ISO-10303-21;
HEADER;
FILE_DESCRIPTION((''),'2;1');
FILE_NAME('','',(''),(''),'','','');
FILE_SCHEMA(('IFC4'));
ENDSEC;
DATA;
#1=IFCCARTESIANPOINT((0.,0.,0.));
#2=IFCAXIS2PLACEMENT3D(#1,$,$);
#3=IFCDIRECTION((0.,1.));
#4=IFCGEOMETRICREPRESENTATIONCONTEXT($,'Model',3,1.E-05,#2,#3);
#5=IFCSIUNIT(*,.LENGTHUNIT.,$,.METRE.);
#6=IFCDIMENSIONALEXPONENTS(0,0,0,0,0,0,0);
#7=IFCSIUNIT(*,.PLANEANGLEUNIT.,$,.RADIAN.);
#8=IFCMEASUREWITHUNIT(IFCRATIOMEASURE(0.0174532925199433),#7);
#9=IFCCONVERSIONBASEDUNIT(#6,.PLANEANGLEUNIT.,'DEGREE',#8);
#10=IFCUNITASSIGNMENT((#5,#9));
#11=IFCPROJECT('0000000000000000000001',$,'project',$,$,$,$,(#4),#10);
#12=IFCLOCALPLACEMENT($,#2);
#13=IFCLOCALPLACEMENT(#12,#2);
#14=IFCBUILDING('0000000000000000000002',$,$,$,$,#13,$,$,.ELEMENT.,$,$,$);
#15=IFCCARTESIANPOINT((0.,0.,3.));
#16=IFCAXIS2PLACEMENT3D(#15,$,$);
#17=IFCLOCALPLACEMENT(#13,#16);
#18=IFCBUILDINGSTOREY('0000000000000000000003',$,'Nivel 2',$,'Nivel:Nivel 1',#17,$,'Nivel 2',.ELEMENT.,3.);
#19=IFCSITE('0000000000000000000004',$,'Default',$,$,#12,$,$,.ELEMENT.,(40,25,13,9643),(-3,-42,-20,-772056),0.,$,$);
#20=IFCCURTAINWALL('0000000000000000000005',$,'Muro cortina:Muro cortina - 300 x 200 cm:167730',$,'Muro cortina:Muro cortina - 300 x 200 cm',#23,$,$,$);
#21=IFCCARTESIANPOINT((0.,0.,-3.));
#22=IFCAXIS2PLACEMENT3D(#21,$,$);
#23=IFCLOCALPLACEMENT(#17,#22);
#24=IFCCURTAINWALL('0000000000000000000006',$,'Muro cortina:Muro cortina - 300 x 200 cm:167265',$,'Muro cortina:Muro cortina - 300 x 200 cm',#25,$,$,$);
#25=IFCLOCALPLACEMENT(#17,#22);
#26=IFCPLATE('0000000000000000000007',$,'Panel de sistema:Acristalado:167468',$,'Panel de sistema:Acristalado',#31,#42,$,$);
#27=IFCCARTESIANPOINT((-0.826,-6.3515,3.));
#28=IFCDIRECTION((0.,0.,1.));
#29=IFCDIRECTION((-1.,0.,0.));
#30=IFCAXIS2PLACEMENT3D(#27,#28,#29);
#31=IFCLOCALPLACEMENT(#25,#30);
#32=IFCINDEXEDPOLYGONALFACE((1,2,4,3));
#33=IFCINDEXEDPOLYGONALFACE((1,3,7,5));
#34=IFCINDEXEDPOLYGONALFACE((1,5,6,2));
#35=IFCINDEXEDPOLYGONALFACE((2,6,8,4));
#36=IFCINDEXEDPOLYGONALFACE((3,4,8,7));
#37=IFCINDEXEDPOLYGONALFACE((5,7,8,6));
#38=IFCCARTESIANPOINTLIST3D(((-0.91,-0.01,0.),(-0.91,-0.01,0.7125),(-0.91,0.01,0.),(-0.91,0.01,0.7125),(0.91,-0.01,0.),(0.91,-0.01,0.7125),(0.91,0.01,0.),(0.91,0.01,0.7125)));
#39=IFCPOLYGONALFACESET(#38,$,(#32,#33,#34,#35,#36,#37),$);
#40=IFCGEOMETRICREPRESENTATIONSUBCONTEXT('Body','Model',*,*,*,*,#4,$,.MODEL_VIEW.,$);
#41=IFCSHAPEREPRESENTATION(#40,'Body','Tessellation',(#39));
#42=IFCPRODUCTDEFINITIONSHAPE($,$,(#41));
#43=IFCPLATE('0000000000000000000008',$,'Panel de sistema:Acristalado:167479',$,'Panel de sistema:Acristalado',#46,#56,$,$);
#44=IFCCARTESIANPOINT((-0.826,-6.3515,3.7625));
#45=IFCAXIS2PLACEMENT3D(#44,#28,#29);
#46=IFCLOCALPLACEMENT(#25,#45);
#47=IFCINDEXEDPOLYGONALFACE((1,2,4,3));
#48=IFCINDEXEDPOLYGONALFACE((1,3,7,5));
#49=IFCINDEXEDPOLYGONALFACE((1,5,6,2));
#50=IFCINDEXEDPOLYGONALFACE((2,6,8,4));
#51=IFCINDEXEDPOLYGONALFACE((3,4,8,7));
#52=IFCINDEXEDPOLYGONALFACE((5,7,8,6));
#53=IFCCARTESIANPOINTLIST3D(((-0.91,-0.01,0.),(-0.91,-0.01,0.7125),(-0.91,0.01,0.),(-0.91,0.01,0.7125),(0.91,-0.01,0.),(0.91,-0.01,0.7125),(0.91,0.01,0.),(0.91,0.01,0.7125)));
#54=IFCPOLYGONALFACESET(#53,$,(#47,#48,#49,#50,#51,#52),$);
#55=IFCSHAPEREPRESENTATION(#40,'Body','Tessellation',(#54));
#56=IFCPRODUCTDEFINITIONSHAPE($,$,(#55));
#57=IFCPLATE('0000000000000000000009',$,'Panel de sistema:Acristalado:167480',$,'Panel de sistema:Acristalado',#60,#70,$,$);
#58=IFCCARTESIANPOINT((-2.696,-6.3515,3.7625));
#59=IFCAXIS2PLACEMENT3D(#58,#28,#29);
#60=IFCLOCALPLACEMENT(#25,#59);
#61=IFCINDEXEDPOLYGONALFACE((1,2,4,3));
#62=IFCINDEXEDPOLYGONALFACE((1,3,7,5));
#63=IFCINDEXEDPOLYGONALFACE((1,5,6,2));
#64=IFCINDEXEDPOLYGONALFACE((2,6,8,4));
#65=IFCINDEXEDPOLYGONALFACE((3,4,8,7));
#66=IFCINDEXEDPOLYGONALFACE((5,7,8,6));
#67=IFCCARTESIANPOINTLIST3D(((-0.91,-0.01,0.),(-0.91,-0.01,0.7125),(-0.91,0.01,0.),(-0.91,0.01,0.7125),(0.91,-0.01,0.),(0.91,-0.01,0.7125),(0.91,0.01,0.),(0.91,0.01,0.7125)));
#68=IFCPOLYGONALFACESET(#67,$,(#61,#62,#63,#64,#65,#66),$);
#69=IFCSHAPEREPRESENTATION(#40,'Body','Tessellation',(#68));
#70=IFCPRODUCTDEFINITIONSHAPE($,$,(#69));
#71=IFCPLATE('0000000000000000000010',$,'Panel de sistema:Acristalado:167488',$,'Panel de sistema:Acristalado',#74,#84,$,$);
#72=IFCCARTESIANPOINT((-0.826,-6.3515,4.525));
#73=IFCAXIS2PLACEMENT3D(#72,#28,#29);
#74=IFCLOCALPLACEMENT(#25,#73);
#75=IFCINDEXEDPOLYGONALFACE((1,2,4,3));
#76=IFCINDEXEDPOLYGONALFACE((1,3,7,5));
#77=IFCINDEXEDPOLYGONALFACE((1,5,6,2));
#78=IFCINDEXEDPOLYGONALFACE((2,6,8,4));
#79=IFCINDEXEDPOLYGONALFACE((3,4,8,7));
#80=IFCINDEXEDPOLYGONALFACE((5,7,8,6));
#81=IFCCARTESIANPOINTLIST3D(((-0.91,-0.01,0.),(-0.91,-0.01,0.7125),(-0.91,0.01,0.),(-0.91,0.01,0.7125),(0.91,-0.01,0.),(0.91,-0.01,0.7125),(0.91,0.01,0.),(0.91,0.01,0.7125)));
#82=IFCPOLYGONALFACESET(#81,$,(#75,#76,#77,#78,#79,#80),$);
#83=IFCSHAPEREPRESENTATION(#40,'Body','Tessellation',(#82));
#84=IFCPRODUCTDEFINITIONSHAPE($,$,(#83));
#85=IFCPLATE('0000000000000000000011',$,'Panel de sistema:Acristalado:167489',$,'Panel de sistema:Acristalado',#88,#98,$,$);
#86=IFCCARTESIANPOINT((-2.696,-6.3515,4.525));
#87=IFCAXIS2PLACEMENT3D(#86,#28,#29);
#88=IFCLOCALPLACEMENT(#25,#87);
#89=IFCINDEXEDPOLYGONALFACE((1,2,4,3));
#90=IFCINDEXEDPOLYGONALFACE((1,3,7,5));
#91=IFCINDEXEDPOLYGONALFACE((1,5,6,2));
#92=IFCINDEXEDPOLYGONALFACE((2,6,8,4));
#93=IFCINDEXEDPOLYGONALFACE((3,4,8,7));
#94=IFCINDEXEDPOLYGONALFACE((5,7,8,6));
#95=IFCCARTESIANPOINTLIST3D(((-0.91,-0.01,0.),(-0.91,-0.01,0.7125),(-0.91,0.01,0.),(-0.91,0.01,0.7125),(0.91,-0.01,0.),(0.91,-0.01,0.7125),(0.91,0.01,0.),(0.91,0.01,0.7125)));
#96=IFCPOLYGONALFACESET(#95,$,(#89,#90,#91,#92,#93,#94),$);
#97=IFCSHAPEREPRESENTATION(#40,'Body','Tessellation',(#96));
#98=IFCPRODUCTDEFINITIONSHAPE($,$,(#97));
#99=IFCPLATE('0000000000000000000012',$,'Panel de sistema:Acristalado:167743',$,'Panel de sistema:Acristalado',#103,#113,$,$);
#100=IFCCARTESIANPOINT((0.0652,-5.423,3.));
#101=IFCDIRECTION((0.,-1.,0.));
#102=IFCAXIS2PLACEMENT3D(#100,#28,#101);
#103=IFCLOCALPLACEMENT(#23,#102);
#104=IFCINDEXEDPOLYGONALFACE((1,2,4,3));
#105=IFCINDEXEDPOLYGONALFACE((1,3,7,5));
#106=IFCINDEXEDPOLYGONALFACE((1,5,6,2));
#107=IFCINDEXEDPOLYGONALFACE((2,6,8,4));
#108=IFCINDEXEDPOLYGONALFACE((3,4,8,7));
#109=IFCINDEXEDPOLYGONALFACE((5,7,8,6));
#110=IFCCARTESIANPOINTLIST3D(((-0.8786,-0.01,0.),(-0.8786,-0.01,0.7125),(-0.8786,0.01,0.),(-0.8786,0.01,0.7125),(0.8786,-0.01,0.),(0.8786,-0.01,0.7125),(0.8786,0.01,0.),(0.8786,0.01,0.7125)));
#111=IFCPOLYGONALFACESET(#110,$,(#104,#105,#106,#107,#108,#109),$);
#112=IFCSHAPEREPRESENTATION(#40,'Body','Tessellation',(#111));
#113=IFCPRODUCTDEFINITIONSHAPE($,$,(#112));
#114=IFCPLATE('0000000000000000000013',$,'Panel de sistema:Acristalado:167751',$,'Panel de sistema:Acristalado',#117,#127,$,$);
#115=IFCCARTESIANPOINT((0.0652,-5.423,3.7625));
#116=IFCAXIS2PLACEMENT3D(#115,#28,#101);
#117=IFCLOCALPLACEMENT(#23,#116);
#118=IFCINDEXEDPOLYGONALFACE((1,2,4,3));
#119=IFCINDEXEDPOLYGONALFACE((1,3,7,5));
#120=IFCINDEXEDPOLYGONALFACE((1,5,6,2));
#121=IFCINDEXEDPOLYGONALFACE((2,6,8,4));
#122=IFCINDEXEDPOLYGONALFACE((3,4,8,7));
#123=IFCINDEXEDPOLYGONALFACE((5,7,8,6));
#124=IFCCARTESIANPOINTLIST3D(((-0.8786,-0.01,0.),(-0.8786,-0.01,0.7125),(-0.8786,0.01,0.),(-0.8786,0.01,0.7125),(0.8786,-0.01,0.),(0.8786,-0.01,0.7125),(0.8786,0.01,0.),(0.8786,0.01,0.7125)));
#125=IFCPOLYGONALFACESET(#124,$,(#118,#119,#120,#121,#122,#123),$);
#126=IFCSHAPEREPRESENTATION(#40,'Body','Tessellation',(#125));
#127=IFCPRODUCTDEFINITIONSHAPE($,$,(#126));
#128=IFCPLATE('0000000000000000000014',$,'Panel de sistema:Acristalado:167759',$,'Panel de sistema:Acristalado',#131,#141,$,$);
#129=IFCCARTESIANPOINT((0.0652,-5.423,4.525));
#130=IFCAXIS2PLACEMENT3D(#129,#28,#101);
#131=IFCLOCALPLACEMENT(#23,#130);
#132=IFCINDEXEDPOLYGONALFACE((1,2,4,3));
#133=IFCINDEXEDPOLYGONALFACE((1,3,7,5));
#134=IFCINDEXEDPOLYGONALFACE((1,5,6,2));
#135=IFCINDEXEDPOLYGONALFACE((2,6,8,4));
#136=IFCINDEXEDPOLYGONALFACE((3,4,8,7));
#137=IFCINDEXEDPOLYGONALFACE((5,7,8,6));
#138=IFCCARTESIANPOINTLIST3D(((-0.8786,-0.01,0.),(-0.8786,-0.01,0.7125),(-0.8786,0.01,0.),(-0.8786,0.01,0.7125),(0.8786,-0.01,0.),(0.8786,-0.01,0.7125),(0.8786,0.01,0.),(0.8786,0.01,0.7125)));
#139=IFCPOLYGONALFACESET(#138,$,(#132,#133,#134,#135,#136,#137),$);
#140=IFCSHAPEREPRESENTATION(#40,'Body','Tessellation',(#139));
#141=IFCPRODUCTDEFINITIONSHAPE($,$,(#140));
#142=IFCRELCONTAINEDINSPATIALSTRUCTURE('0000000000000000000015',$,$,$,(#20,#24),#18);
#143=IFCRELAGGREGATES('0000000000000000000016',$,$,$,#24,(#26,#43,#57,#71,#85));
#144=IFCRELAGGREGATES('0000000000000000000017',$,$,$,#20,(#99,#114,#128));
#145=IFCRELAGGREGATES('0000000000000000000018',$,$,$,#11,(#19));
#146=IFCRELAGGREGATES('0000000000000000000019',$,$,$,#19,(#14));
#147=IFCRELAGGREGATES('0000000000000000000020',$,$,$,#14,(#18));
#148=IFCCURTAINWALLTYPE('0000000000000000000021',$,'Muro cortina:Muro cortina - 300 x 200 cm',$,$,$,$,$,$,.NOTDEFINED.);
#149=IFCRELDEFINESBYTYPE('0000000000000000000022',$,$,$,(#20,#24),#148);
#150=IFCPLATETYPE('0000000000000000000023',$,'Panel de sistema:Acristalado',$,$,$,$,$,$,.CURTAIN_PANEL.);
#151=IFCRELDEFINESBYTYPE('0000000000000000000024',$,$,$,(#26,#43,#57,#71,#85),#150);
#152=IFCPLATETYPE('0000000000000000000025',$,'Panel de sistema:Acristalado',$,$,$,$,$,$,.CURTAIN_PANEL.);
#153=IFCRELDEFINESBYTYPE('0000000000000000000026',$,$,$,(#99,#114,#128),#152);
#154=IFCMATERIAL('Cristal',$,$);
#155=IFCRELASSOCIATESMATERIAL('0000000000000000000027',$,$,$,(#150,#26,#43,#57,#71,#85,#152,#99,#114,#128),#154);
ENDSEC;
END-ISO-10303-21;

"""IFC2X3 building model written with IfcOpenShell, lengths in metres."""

from ifc_helpers import new_model, entity, si_unit, converted_unit, direction, frame, origin, origin_2d_with_axis, place, context, subcontext, project, spatial, rectangle, extrude, source, transform, mapped, material, type_object, type_shapes, element, aggregate, save


model = new_model("IFC2X3")

# Units and contexts
model_context = context("Model", 3, precision=1e-05, world=origin(), true_north=direction((0.0, 1.0)))
body_context = subcontext(model_context, "Body", "Model", "MODEL_VIEW")
ifc_project = project(units=[si_unit("LENGTHUNIT", "METRE"), converted_unit("PLANEANGLEUNIT", "DEGREE", entity("IfcRatioMeasure", 0.0174532925199433), si_unit("PLANEANGLEUNIT", "RADIAN"), dimensions=[0, 0, 0, 0, 0, 0, 0])], contexts=[model_context])

# Site, building, storey
site_placement = place(None, origin())
site = spatial("IfcSite", under=ifc_project, at=site_placement, Name="Default", CompositionType="ELEMENT", RefLatitude=(40, 25, 13, 9643), RefLongitude=(-3, -42, -20, -772056), RefElevation=0.0)
building_placement = place(site_placement, origin())
building = spatial("IfcBuilding", under=site, at=building_placement, CompositionType="ELEMENT")
storey_placement = place(building_placement, frame((0.0, 0.0, 3.0)))
storey = spatial("IfcBuildingStorey", under=building, at=storey_placement, Name="Nivel 2", ObjectType="Nivel:Nivel 1", LongName="Nivel 2", CompositionType="ELEMENT", Elevation=3.0)

# Curtain walls
curtain_wall_type = type_object("IfcCurtainWallType", Name="Muro cortina:Muro cortina - 300 x 200 cm", PredefinedType="NOTDEFINED")
curtain_wall_1_placement = place(storey_placement, frame((0.0, 0.0, -3.0)))
curtain_wall_1 = element("IfcCurtainWall", 1, at=curtain_wall_1_placement, inside=storey, type_object=curtain_wall_type, Name="Muro cortina:Muro cortina - 300 x 200 cm:167730", ObjectType="Muro cortina:Muro cortina - 300 x 200 cm")
curtain_wall_2_placement = place(storey_placement, frame((0.0, 0.0, -3.0)))
curtain_wall_2 = element("IfcCurtainWall", 2, at=curtain_wall_2_placement, inside=storey, type_object=curtain_wall_type, Name="Muro cortina:Muro cortina - 300 x 200 cm:167265", ObjectType="Muro cortina:Muro cortina - 300 x 200 cm")

# Plates
ifc_material_1 = material(Name="Cristal")
plate_type_1 = type_object("IfcPlateType", Name="Panel de sistema:Acristalado", PredefinedType="CURTAIN_PANEL", material=ifc_material_1)
shared_shape_1 = source(origin(), body_context, "Body", "SweptSolid", [
    extrude(rectangle(XDim=0.02, YDim=1.82, at=origin_2d_with_axis()), frame((0.0, 0.0, 0.0), z_axis=(0.0, 0.0, 1.0), x_axis=(0.0, 1.0, 0.0)), (0.0, 0.0, 1.0), 0.7125),
])
type_shapes(plate_type_1, [shared_shape_1])
plate_1_placement = place(curtain_wall_2_placement, frame((-0.826, -6.3515, 3.0), z_axis=(0.0, 0.0, 1.0), x_axis=(-1.0, 0.0, 0.0)))
plate_1 = element("IfcPlate", 3, at=plate_1_placement, type_object=plate_type_1, material=ifc_material_1, Name="Panel de sistema:Acristalado:167468", ObjectType="Panel de sistema:Acristalado", context=body_context, shape_type="MappedRepresentation", body=[
    mapped(shared_shape_1, transform((0.0, 0.0, 0.0), scale=1.0)),
])
plate_2_placement = place(curtain_wall_2_placement, frame((-0.826, -6.3515, 3.7625), z_axis=(0.0, 0.0, 1.0), x_axis=(-1.0, 0.0, 0.0)))
plate_2 = element("IfcPlate", 4, at=plate_2_placement, type_object=plate_type_1, material=ifc_material_1, Name="Panel de sistema:Acristalado:167479", ObjectType="Panel de sistema:Acristalado", context=body_context, shape_type="MappedRepresentation", body=[
    mapped(shared_shape_1, transform((0.0, 0.0, 0.0), scale=1.0)),
])
plate_3_placement = place(curtain_wall_2_placement, frame((-2.696, -6.3515, 3.7625), z_axis=(0.0, 0.0, 1.0), x_axis=(-1.0, 0.0, 0.0)))
plate_3 = element("IfcPlate", 5, at=plate_3_placement, type_object=plate_type_1, material=ifc_material_1, Name="Panel de sistema:Acristalado:167480", ObjectType="Panel de sistema:Acristalado", context=body_context, shape_type="MappedRepresentation", body=[
    mapped(shared_shape_1, transform((0.0, 0.0, 0.0), scale=1.0)),
])
plate_4_placement = place(curtain_wall_2_placement, frame((-0.826, -6.3515, 4.525), z_axis=(0.0, 0.0, 1.0), x_axis=(-1.0, 0.0, 0.0)))
plate_4 = element("IfcPlate", 6, at=plate_4_placement, type_object=plate_type_1, material=ifc_material_1, Name="Panel de sistema:Acristalado:167488", ObjectType="Panel de sistema:Acristalado", context=body_context, shape_type="MappedRepresentation", body=[
    mapped(shared_shape_1, transform((0.0, 0.0, 0.0), scale=1.0)),
])
plate_5_placement = place(curtain_wall_2_placement, frame((-2.696, -6.3515, 4.525), z_axis=(0.0, 0.0, 1.0), x_axis=(-1.0, 0.0, 0.0)))
plate_5 = element("IfcPlate", 7, at=plate_5_placement, type_object=plate_type_1, material=ifc_material_1, Name="Panel de sistema:Acristalado:167489", ObjectType="Panel de sistema:Acristalado", context=body_context, shape_type="MappedRepresentation", body=[
    mapped(shared_shape_1, transform((0.0, 0.0, 0.0), scale=1.0)),
])
aggregate(curtain_wall_2, [plate_1, plate_2, plate_3, plate_4, plate_5])
plate_type_2 = type_object("IfcPlateType", Name="Panel de sistema:Acristalado", PredefinedType="CURTAIN_PANEL", material=ifc_material_1)
shared_shape_2 = source(origin(), body_context, "Body", "SweptSolid", [
    extrude(rectangle(XDim=0.02, YDim=1.7571, at=origin_2d_with_axis()), frame((0.0, 0.0, 0.0), z_axis=(0.0, 0.0, 1.0), x_axis=(0.0, 1.0, 0.0)), (0.0, 0.0, 1.0), 0.7125),
])
type_shapes(plate_type_2, [shared_shape_2])
plate_6_placement = place(curtain_wall_1_placement, frame((0.0652, -5.423, 3.0), z_axis=(0.0, 0.0, 1.0), x_axis=(0.0, -1.0, 0.0)))
plate_6 = element("IfcPlate", 8, at=plate_6_placement, type_object=plate_type_2, material=ifc_material_1, Name="Panel de sistema:Acristalado:167743", ObjectType="Panel de sistema:Acristalado", context=body_context, shape_type="MappedRepresentation", body=[
    mapped(shared_shape_2, transform((0.0, 0.0, 0.0), scale=1.0)),
])
plate_7_placement = place(curtain_wall_1_placement, frame((0.0652, -5.423, 3.7625), z_axis=(0.0, 0.0, 1.0), x_axis=(0.0, -1.0, 0.0)))
plate_7 = element("IfcPlate", 9, at=plate_7_placement, type_object=plate_type_2, material=ifc_material_1, Name="Panel de sistema:Acristalado:167751", ObjectType="Panel de sistema:Acristalado", context=body_context, shape_type="MappedRepresentation", body=[
    mapped(shared_shape_2, transform((0.0, 0.0, 0.0), scale=1.0)),
])
plate_8_placement = place(curtain_wall_1_placement, frame((0.0652, -5.423, 4.525), z_axis=(0.0, 0.0, 1.0), x_axis=(0.0, -1.0, 0.0)))
plate_8 = element("IfcPlate", 10, at=plate_8_placement, type_object=plate_type_2, material=ifc_material_1, Name="Panel de sistema:Acristalado:167759", ObjectType="Panel de sistema:Acristalado", context=body_context, shape_type="MappedRepresentation", body=[
    mapped(shared_shape_2, transform((0.0, 0.0, 0.0), scale=1.0)),
])
aggregate(curtain_wall_1, [plate_6, plate_7, plate_8])

save(model, "model.ifc")
